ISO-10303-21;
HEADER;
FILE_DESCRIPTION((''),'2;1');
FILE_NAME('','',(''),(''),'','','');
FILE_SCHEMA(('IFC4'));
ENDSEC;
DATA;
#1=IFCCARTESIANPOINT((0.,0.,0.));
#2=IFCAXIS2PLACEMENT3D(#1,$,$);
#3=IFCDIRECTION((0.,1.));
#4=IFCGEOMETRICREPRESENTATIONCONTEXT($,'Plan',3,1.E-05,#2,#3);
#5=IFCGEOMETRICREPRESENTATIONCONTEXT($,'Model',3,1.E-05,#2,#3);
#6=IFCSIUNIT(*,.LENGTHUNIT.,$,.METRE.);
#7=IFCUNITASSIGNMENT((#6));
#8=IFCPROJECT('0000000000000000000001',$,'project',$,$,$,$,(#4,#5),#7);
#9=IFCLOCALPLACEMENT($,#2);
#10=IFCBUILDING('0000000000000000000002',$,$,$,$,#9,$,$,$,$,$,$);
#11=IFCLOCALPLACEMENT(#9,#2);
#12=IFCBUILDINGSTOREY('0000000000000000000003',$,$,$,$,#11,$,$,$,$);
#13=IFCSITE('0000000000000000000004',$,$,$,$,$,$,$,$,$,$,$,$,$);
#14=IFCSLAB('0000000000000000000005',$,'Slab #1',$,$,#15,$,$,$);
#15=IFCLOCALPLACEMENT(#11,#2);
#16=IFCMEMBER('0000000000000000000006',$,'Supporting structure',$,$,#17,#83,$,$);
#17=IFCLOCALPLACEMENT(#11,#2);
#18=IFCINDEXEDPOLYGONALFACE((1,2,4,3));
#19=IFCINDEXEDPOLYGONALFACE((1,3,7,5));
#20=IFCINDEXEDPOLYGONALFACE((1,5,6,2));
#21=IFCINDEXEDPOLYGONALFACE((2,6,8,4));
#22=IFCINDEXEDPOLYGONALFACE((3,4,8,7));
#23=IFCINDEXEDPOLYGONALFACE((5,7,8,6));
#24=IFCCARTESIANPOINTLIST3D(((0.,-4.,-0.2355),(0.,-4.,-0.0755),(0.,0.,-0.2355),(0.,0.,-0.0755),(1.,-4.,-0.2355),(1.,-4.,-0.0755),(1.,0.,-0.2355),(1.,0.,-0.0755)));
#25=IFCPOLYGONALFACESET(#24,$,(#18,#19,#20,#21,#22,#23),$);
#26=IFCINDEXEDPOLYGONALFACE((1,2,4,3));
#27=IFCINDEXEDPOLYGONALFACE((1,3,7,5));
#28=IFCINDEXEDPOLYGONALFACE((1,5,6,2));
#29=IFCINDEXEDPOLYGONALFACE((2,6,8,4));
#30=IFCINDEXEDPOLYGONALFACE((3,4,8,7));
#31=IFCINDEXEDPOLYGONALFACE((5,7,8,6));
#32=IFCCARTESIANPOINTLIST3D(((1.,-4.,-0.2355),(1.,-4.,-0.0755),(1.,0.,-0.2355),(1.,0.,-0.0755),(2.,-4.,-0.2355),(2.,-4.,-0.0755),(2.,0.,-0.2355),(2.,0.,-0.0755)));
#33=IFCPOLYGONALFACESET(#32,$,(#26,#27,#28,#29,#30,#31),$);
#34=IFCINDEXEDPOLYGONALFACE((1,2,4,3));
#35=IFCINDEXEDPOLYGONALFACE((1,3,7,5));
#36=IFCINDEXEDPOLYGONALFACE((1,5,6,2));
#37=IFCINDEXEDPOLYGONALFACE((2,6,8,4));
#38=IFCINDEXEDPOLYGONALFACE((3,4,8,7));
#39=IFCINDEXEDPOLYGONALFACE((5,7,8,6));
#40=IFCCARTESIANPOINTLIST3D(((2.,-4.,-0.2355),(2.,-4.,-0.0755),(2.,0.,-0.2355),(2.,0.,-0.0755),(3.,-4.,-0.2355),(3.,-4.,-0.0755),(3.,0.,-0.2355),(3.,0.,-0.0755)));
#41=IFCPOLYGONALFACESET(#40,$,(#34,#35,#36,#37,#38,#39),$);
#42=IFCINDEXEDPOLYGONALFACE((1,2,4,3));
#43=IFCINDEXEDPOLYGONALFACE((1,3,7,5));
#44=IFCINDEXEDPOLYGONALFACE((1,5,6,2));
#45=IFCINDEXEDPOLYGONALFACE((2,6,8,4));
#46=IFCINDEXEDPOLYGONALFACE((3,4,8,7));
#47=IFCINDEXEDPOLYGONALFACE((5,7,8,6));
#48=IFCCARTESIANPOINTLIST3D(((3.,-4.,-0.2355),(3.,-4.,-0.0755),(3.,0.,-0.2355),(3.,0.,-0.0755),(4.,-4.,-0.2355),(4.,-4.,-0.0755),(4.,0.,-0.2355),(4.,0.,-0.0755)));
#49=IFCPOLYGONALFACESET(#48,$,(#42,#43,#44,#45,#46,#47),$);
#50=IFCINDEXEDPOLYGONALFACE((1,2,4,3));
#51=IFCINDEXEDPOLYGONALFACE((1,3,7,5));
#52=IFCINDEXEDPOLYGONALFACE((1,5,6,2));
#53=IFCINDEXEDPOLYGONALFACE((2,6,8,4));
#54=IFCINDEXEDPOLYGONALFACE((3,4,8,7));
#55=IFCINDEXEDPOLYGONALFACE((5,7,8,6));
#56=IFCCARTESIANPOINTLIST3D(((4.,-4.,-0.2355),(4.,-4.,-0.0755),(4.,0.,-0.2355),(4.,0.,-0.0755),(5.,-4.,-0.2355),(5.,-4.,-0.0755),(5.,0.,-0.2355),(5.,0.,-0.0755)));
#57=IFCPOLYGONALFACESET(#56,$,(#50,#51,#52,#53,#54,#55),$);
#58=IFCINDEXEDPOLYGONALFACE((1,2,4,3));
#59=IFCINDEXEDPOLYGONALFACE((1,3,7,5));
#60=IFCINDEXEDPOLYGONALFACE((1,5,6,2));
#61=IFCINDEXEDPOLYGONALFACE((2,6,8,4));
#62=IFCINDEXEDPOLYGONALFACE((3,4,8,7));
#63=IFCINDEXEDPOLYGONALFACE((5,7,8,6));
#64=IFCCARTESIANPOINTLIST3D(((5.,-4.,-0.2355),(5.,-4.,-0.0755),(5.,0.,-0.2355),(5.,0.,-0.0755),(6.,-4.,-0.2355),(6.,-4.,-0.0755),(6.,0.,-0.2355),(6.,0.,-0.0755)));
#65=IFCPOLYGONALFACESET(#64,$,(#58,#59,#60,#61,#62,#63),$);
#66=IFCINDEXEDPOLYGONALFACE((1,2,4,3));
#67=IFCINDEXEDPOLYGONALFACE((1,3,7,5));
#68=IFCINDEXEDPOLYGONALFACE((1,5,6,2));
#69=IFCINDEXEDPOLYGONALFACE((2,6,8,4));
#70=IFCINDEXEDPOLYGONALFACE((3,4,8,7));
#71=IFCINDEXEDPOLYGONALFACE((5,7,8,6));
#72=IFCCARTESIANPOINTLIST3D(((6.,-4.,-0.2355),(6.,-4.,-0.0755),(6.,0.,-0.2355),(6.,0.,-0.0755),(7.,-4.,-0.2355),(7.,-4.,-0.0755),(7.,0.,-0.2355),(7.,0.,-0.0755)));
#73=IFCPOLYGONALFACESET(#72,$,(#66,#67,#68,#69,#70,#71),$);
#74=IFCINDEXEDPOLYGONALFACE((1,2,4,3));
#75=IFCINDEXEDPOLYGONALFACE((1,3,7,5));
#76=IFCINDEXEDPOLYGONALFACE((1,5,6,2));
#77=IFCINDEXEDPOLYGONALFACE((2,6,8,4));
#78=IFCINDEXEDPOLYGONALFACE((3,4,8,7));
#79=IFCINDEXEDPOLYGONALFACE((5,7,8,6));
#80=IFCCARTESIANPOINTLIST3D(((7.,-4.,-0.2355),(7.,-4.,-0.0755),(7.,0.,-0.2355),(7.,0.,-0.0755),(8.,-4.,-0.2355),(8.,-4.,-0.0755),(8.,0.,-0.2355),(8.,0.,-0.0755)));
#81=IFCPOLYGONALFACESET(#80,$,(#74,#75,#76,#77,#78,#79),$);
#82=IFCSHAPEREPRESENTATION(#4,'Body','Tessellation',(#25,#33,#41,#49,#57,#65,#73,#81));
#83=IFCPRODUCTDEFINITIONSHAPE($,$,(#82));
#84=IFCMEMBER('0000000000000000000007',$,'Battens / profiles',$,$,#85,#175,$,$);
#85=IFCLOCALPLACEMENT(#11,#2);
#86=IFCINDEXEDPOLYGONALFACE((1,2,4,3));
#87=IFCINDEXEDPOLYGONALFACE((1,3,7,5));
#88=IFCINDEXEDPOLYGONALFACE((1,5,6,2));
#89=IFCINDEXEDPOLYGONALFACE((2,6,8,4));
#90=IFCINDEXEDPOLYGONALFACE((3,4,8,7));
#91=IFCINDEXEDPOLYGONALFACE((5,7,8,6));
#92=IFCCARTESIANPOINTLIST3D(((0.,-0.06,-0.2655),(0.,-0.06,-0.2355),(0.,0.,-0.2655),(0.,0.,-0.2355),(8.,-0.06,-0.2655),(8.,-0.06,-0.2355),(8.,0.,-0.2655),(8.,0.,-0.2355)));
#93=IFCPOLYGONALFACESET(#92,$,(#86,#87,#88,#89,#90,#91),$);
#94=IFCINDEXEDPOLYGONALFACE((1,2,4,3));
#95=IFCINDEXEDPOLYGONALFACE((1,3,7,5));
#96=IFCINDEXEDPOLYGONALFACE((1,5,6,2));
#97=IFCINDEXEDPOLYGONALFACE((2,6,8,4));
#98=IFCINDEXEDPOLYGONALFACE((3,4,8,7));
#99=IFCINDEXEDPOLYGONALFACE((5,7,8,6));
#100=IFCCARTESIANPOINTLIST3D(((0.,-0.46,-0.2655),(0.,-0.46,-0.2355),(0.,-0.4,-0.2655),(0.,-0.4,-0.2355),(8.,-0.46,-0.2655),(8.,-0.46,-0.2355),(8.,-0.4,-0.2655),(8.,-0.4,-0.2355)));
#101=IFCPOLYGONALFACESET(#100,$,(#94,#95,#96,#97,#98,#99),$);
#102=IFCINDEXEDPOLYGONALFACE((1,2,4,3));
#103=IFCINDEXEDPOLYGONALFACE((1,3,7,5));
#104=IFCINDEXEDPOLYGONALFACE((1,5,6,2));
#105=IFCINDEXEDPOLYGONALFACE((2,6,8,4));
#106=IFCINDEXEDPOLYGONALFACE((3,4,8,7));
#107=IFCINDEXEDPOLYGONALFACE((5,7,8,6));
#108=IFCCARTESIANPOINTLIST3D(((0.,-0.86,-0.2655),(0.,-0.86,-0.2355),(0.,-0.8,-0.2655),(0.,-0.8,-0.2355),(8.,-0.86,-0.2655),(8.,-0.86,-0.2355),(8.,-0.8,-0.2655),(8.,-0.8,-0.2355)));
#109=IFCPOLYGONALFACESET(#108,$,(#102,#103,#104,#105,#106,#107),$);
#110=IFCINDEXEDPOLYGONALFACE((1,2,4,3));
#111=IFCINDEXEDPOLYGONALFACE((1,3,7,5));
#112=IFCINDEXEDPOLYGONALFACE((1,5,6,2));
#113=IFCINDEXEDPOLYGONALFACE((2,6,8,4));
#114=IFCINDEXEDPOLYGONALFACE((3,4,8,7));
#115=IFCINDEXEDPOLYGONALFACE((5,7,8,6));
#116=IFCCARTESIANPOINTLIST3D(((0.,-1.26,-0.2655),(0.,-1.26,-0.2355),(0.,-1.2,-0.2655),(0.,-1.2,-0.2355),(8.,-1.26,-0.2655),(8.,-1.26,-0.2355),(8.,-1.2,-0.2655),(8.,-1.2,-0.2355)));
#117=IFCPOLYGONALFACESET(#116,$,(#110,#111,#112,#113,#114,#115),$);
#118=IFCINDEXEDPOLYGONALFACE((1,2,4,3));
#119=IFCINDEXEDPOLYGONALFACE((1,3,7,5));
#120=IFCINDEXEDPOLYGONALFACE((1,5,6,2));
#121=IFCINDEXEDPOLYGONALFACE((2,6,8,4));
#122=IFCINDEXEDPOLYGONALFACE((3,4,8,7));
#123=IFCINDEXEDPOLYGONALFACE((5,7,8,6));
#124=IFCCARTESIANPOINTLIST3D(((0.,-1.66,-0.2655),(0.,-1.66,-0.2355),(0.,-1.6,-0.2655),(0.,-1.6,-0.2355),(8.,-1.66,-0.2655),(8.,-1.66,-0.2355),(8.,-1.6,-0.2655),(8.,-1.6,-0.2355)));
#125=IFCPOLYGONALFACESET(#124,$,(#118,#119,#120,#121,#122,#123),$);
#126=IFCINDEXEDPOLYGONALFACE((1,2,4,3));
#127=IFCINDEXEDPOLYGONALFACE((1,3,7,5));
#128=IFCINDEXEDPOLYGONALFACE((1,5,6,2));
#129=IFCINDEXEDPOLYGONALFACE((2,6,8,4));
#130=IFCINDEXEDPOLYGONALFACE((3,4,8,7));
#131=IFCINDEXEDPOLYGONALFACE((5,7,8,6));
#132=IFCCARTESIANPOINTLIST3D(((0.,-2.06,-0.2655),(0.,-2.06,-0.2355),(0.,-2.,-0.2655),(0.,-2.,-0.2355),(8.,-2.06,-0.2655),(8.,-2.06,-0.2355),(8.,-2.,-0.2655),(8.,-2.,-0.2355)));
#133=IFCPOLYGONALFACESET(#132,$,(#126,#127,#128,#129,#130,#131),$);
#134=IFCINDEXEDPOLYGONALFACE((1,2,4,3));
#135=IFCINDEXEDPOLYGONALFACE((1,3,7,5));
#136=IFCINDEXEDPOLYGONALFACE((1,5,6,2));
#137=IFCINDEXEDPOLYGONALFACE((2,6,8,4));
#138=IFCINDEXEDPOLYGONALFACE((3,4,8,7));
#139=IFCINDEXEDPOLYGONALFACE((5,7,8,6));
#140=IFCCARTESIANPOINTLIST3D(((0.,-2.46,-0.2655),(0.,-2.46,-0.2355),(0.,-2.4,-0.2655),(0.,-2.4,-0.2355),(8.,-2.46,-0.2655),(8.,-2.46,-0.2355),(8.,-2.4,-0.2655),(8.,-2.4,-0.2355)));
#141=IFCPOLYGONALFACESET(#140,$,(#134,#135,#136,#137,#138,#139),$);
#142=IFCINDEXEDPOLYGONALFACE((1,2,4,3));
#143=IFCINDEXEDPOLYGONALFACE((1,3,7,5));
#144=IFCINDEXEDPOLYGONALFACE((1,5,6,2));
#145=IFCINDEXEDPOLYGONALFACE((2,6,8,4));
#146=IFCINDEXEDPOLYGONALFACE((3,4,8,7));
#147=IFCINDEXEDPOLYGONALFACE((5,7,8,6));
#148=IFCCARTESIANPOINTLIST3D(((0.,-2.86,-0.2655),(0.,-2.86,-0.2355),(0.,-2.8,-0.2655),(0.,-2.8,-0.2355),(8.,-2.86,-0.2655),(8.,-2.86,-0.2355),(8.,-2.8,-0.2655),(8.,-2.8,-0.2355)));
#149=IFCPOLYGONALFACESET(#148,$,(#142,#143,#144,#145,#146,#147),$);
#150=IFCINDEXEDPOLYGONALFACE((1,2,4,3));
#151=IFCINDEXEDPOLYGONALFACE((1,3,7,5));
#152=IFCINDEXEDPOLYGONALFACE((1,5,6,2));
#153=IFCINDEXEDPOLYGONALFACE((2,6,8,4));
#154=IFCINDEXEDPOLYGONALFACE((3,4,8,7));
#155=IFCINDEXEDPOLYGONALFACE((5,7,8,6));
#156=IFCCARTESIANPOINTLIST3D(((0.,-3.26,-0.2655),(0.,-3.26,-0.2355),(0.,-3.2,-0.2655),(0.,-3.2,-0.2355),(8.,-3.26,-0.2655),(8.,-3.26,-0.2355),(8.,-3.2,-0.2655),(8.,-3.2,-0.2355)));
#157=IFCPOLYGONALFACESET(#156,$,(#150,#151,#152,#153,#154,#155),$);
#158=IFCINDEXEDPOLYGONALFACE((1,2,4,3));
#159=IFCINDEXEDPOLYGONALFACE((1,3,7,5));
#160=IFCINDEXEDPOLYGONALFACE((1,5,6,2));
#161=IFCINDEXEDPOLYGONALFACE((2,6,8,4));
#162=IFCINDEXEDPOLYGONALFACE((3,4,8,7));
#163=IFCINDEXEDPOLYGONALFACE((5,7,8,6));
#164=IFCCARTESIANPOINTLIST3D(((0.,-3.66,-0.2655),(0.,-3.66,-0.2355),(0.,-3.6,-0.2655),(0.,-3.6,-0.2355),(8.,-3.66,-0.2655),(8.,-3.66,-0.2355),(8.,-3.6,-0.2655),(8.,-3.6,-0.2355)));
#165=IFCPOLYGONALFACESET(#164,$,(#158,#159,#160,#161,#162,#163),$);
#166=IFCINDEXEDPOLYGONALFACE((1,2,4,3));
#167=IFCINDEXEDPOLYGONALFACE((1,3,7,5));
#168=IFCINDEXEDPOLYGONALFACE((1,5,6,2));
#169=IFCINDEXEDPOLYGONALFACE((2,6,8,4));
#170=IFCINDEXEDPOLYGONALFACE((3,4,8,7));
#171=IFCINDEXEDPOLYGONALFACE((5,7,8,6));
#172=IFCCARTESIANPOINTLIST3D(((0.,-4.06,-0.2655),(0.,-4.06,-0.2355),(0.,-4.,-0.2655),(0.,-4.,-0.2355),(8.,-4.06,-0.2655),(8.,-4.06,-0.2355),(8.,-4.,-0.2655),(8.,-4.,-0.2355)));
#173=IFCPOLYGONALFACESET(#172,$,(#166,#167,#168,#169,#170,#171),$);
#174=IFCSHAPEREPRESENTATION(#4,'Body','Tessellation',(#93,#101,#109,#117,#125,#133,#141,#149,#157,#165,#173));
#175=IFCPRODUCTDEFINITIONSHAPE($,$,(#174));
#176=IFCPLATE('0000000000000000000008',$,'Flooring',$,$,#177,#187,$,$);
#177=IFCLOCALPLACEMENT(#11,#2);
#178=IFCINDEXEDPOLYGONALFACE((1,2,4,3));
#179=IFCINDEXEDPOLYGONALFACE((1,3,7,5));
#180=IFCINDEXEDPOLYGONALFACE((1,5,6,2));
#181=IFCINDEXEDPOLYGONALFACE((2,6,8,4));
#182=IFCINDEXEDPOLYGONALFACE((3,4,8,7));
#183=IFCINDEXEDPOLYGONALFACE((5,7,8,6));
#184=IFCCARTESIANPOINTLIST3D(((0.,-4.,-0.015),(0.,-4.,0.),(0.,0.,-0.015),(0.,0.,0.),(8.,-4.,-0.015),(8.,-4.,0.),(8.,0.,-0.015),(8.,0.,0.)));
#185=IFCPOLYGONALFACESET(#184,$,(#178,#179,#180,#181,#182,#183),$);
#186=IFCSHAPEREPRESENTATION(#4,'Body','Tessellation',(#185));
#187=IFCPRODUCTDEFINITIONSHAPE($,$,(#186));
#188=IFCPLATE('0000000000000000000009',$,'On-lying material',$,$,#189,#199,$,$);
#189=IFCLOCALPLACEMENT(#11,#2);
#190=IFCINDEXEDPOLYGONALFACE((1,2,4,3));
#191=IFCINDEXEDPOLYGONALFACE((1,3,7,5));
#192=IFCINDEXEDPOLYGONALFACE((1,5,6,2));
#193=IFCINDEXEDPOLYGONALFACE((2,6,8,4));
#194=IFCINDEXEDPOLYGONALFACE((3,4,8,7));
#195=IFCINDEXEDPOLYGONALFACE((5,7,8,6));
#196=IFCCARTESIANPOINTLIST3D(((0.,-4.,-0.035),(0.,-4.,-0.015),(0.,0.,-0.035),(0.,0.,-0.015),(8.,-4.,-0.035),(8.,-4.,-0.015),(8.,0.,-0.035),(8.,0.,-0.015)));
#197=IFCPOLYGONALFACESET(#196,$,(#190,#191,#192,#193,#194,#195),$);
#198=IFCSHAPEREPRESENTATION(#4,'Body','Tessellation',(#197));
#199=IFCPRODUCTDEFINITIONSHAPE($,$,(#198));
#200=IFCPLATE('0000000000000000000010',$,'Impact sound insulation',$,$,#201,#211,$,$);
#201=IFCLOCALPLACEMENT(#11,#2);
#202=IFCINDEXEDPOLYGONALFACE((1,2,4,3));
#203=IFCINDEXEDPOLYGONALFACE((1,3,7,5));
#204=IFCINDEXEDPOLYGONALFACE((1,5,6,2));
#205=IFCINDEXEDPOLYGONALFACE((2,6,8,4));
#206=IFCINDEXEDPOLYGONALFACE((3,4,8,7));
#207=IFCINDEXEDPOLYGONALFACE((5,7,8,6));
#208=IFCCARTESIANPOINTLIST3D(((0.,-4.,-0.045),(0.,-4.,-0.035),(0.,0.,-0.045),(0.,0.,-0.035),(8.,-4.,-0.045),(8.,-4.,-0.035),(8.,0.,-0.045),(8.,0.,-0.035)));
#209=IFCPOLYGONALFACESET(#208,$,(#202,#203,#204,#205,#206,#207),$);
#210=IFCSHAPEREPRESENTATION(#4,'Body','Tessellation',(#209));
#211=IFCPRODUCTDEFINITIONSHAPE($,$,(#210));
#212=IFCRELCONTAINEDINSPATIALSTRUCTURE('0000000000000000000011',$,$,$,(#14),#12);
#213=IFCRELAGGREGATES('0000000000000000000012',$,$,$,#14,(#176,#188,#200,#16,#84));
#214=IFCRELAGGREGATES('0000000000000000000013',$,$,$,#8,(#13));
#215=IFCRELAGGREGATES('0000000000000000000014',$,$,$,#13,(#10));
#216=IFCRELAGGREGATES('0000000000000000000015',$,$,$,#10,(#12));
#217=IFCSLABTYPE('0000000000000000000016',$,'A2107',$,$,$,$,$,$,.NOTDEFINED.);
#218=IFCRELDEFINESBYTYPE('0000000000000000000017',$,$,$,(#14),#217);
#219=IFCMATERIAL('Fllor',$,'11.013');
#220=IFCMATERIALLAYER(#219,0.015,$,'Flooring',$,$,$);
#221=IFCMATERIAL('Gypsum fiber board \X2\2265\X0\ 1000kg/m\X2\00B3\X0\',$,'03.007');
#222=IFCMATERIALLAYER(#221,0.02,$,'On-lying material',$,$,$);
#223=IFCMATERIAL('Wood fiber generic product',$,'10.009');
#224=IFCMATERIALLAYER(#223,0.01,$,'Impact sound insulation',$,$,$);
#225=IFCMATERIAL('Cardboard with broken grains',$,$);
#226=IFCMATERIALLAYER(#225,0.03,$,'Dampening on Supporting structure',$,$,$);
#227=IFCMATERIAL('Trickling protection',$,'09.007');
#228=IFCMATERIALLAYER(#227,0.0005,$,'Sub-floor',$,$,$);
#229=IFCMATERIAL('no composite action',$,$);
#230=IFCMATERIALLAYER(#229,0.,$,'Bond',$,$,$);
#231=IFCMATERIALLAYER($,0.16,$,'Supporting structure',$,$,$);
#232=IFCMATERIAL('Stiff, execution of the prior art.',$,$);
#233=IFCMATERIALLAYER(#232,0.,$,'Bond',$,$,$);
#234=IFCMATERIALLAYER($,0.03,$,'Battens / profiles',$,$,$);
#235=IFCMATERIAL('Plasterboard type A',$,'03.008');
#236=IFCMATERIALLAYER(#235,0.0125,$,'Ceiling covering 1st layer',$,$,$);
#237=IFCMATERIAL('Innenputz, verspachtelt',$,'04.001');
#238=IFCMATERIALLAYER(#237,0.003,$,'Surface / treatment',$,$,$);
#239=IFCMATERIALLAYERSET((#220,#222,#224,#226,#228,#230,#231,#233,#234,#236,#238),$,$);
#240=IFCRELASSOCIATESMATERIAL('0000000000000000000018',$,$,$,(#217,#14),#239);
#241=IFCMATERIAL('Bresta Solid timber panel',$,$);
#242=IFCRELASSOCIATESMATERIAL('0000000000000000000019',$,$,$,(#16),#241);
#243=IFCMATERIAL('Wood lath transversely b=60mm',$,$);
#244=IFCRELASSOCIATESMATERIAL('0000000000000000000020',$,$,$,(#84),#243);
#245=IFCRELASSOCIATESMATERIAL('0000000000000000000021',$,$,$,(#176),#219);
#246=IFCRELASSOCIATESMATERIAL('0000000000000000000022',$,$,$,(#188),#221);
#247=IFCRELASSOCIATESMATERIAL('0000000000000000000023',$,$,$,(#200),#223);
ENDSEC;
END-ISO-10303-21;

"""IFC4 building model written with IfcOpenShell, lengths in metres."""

from ifc_helpers import new_model, si_unit, direction, frame, frame_2d, origin, origin_with_axes, place, context, project, spatial, rectangle, extrude, material, layer, layer_set, type_object, element, aggregate, save


model = new_model("IFC4")

# Units and contexts
plan_context = context("Plan", 3, precision=1e-05, world=origin(), true_north=direction((0.0, 1.0)))
model_context = context("Model", 3, precision=1e-05, world=origin(), true_north=direction((0.0, 1.0)))
ifc_project = project(units=[si_unit("LENGTHUNIT", "METRE")], contexts=[plan_context, model_context])

# Site, building, storey
site = spatial("IfcSite", under=ifc_project)
building_placement = place(None, origin())
building = spatial("IfcBuilding", under=site, at=building_placement)
storey_placement = place(building_placement, origin())
storey = spatial("IfcBuildingStorey", under=building, at=storey_placement)

# Slab, members, plates
ifc_material_1 = material(Name="Fllor", Category="11.013")
ifc_layer_1 = layer(ifc_material_1, 0.015, Name="Flooring")
ifc_material_2 = material(Name="Gypsum fiber board ≥ 1000kg/m³", Category="03.007")
ifc_layer_2 = layer(ifc_material_2, 0.02, Name="On-lying material")
ifc_material_3 = material(Name="Wood fiber generic product", Category="10.009")
ifc_layer_3 = layer(ifc_material_3, 0.01, Name="Impact sound insulation")
ifc_material_4 = material(Name="Cardboard with broken grains")
ifc_layer_4 = layer(ifc_material_4, 0.03, Name="Dampening on Supporting structure")
ifc_material_5 = material(Name="Trickling protection", Category="09.007")
ifc_layer_5 = layer(ifc_material_5, 0.0005, Name="Sub-floor")
ifc_material_6 = material(Name="no composite action")
ifc_layer_6 = layer(ifc_material_6, 0.0, Name="Bond")
ifc_layer_7 = layer(None, 0.16, Name="Supporting structure")
ifc_material_7 = material(Name="Stiff, execution of the prior art.")
ifc_layer_8 = layer(ifc_material_7, 0.0, Name="Bond")
ifc_layer_9 = layer(None, 0.03, Name="Battens / profiles")
ifc_material_8 = material(Name="Plasterboard type A", Category="03.008")
ifc_layer_10 = layer(ifc_material_8, 0.0125, Name="Ceiling covering 1st layer")
ifc_material_9 = material(Name="Innenputz, verspachtelt", Category="04.001")
ifc_layer_11 = layer(ifc_material_9, 0.003, Name="Surface / treatment")
ifc_layer_set = layer_set([ifc_layer_1, ifc_layer_2, ifc_layer_3, ifc_layer_4, ifc_layer_5, ifc_layer_6, ifc_layer_7, ifc_layer_8, ifc_layer_9, ifc_layer_10, ifc_layer_11])
slab_type = type_object("IfcSlabType", Name="A2107", PredefinedType="NOTDEFINED", material=ifc_layer_set)
slab_placement = place(None, frame((0.0, 0.0, 0.0), z_axis=(0.0, 0.0, -1.0), x_axis=(1.0, 0.0, 0.0)))
slab = element("IfcSlab", 1, at=slab_placement, inside=storey, type_object=slab_type, material=ifc_layer_set, Name="Slab #1")
ifc_material_10 = material(Name="Bresta Solid timber panel")
member_1_placement = place(slab_placement, origin())
member_1 = element("IfcMember", 2, at=member_1_placement, material=ifc_material_10, Name="Supporting structure", context=plan_context, shape_type="SweptSolid", body=[
    extrude(rectangle(XDim=1.0, YDim=0.16, at=frame_2d((0.5, 0.08), x_axis=(1.0, 0.0))), frame((0.0, 4.0, 0.0755), z_axis=(0.0, -1.0, 0.0), x_axis=(1.0, 0.0, 0.0)), (0.0, 0.0, 1.0), 4.0),
    extrude(rectangle(XDim=1.0, YDim=0.16, at=frame_2d((0.5, 0.08), x_axis=(1.0, 0.0))), frame((1.0, 4.0, 0.0755), z_axis=(0.0, -1.0, 0.0), x_axis=(1.0, 0.0, 0.0)), (0.0, 0.0, 1.0), 4.0),
    extrude(rectangle(XDim=1.0, YDim=0.16, at=frame_2d((0.5, 0.08), x_axis=(1.0, 0.0))), frame((2.0, 4.0, 0.0755), z_axis=(0.0, -1.0, 0.0), x_axis=(1.0, 0.0, 0.0)), (0.0, 0.0, 1.0), 4.0),
    extrude(rectangle(XDim=1.0, YDim=0.16, at=frame_2d((0.5, 0.08), x_axis=(1.0, 0.0))), frame((3.0, 4.0, 0.0755), z_axis=(0.0, -1.0, 0.0), x_axis=(1.0, 0.0, 0.0)), (0.0, 0.0, 1.0), 4.0),
    extrude(rectangle(XDim=1.0, YDim=0.16, at=frame_2d((0.5, 0.08), x_axis=(1.0, 0.0))), frame((4.0, 4.0, 0.0755), z_axis=(0.0, -1.0, 0.0), x_axis=(1.0, 0.0, 0.0)), (0.0, 0.0, 1.0), 4.0),
    extrude(rectangle(XDim=1.0, YDim=0.16, at=frame_2d((0.5, 0.08), x_axis=(1.0, 0.0))), frame((5.0, 4.0, 0.0755), z_axis=(0.0, -1.0, 0.0), x_axis=(1.0, 0.0, 0.0)), (0.0, 0.0, 1.0), 4.0),
    extrude(rectangle(XDim=1.0, YDim=0.16, at=frame_2d((0.5, 0.08), x_axis=(1.0, 0.0))), frame((6.0, 4.0, 0.0755), z_axis=(0.0, -1.0, 0.0), x_axis=(1.0, 0.0, 0.0)), (0.0, 0.0, 1.0), 4.0),
    extrude(rectangle(XDim=1.0, YDim=0.16, at=frame_2d((0.5, 0.08), x_axis=(1.0, 0.0))), frame((7.0, 4.0, 0.0755), z_axis=(0.0, -1.0, 0.0), x_axis=(1.0, 0.0, 0.0)), (0.0, 0.0, 1.0), 4.0),
])
ifc_material_11 = material(Name="Wood lath transversely b=60mm")
member_2_placement = place(slab_placement, origin())
member_2 = element("IfcMember", 3, at=member_2_placement, material=ifc_material_11, Name="Battens / profiles", context=plan_context, shape_type="SweptSolid", body=[
    extrude(rectangle(XDim=0.06, YDim=0.03, at=frame_2d((0.03, 0.015), x_axis=(1.0, 0.0))), frame((0.0, 0.0, 0.2355), z_axis=(1.0, 0.0, 0.0), x_axis=(0.0, 1.0, 0.0)), (0.0, 0.0, 1.0), 8.0),
    extrude(rectangle(XDim=0.06, YDim=0.03, at=frame_2d((0.03, 0.015), x_axis=(1.0, 0.0))), frame((0.0, 0.4, 0.2355), z_axis=(1.0, 0.0, 0.0), x_axis=(0.0, 1.0, 0.0)), (0.0, 0.0, 1.0), 8.0),
    extrude(rectangle(XDim=0.06, YDim=0.03, at=frame_2d((0.03, 0.015), x_axis=(1.0, 0.0))), frame((0.0, 0.8, 0.2355), z_axis=(1.0, 0.0, 0.0), x_axis=(0.0, 1.0, 0.0)), (0.0, 0.0, 1.0), 8.0),
    extrude(rectangle(XDim=0.06, YDim=0.03, at=frame_2d((0.03, 0.015), x_axis=(1.0, 0.0))), frame((0.0, 1.2, 0.2355), z_axis=(1.0, 0.0, 0.0), x_axis=(0.0, 1.0, 0.0)), (0.0, 0.0, 1.0), 8.0),
    extrude(rectangle(XDim=0.06, YDim=0.03, at=frame_2d((0.03, 0.015), x_axis=(1.0, 0.0))), frame((0.0, 1.6, 0.2355), z_axis=(1.0, 0.0, 0.0), x_axis=(0.0, 1.0, 0.0)), (0.0, 0.0, 1.0), 8.0),
    extrude(rectangle(XDim=0.06, YDim=0.03, at=frame_2d((0.03, 0.015), x_axis=(1.0, 0.0))), frame((0.0, 2.0, 0.2355), z_axis=(1.0, 0.0, 0.0), x_axis=(0.0, 1.0, 0.0)), (0.0, 0.0, 1.0), 8.0),
    extrude(rectangle(XDim=0.06, YDim=0.03, at=frame_2d((0.03, 0.015), x_axis=(1.0, 0.0))), frame((0.0, 2.4, 0.2355), z_axis=(1.0, 0.0, 0.0), x_axis=(0.0, 1.0, 0.0)), (0.0, 0.0, 1.0), 8.0),
    extrude(rectangle(XDim=0.06, YDim=0.03, at=frame_2d((0.03, 0.015), x_axis=(1.0, 0.0))), frame((0.0, 2.8, 0.2355), z_axis=(1.0, 0.0, 0.0), x_axis=(0.0, 1.0, 0.0)), (0.0, 0.0, 1.0), 8.0),
    extrude(rectangle(XDim=0.06, YDim=0.03, at=frame_2d((0.03, 0.015), x_axis=(1.0, 0.0))), frame((0.0, 3.2, 0.2355), z_axis=(1.0, 0.0, 0.0), x_axis=(0.0, 1.0, 0.0)), (0.0, 0.0, 1.0), 8.0),
    extrude(rectangle(XDim=0.06, YDim=0.03, at=frame_2d((0.03, 0.015), x_axis=(1.0, 0.0))), frame((0.0, 3.6, 0.2355), z_axis=(1.0, 0.0, 0.0), x_axis=(0.0, 1.0, 0.0)), (0.0, 0.0, 1.0), 8.0),
    extrude(rectangle(XDim=0.06, YDim=0.03, at=frame_2d((0.03, 0.015), x_axis=(1.0, 0.0))), frame((0.0, 4.0, 0.2355), z_axis=(1.0, 0.0, 0.0), x_axis=(0.0, 1.0, 0.0)), (0.0, 0.0, 1.0), 8.0),
])
plate_1_placement = place(slab_placement, origin())
plate_1 = element("IfcPlate", 4, at=plate_1_placement, material=ifc_material_1, Name="Flooring", context=plan_context, shape_type="SweptSolid", body=[
    extrude(rectangle(XDim=8.0, YDim=4.0, at=frame_2d((4.0, 2.0), x_axis=(1.0, 0.0))), origin_with_axes(), (0.0, 0.0, 1.0), 0.015),
])
plate_2_placement = place(slab_placement, origin())
plate_2 = element("IfcPlate", 5, at=plate_2_placement, material=ifc_material_2, Name="On-lying material", context=plan_context, shape_type="SweptSolid", body=[
    extrude(rectangle(XDim=8.0, YDim=4.0, at=frame_2d((4.0, 2.0), x_axis=(1.0, 0.0))), frame((0.0, 0.0, 0.015), z_axis=(0.0, 0.0, 1.0), x_axis=(1.0, 0.0, 0.0)), (0.0, 0.0, 1.0), 0.02),
])
plate_3_placement = place(slab_placement, origin())
plate_3 = element("IfcPlate", 6, at=plate_3_placement, material=ifc_material_3, Name="Impact sound insulation", context=plan_context, shape_type="SweptSolid", body=[
    extrude(rectangle(XDim=8.0, YDim=4.0, at=frame_2d((4.0, 2.0), x_axis=(1.0, 0.0))), frame((0.0, 0.0, 0.035), z_axis=(0.0, 0.0, 1.0), x_axis=(1.0, 0.0, 0.0)), (0.0, 0.0, 1.0), 0.01),
])
aggregate(slab, [plate_1, plate_2, plate_3, member_1, member_2])

save(model, "model.ifc")
